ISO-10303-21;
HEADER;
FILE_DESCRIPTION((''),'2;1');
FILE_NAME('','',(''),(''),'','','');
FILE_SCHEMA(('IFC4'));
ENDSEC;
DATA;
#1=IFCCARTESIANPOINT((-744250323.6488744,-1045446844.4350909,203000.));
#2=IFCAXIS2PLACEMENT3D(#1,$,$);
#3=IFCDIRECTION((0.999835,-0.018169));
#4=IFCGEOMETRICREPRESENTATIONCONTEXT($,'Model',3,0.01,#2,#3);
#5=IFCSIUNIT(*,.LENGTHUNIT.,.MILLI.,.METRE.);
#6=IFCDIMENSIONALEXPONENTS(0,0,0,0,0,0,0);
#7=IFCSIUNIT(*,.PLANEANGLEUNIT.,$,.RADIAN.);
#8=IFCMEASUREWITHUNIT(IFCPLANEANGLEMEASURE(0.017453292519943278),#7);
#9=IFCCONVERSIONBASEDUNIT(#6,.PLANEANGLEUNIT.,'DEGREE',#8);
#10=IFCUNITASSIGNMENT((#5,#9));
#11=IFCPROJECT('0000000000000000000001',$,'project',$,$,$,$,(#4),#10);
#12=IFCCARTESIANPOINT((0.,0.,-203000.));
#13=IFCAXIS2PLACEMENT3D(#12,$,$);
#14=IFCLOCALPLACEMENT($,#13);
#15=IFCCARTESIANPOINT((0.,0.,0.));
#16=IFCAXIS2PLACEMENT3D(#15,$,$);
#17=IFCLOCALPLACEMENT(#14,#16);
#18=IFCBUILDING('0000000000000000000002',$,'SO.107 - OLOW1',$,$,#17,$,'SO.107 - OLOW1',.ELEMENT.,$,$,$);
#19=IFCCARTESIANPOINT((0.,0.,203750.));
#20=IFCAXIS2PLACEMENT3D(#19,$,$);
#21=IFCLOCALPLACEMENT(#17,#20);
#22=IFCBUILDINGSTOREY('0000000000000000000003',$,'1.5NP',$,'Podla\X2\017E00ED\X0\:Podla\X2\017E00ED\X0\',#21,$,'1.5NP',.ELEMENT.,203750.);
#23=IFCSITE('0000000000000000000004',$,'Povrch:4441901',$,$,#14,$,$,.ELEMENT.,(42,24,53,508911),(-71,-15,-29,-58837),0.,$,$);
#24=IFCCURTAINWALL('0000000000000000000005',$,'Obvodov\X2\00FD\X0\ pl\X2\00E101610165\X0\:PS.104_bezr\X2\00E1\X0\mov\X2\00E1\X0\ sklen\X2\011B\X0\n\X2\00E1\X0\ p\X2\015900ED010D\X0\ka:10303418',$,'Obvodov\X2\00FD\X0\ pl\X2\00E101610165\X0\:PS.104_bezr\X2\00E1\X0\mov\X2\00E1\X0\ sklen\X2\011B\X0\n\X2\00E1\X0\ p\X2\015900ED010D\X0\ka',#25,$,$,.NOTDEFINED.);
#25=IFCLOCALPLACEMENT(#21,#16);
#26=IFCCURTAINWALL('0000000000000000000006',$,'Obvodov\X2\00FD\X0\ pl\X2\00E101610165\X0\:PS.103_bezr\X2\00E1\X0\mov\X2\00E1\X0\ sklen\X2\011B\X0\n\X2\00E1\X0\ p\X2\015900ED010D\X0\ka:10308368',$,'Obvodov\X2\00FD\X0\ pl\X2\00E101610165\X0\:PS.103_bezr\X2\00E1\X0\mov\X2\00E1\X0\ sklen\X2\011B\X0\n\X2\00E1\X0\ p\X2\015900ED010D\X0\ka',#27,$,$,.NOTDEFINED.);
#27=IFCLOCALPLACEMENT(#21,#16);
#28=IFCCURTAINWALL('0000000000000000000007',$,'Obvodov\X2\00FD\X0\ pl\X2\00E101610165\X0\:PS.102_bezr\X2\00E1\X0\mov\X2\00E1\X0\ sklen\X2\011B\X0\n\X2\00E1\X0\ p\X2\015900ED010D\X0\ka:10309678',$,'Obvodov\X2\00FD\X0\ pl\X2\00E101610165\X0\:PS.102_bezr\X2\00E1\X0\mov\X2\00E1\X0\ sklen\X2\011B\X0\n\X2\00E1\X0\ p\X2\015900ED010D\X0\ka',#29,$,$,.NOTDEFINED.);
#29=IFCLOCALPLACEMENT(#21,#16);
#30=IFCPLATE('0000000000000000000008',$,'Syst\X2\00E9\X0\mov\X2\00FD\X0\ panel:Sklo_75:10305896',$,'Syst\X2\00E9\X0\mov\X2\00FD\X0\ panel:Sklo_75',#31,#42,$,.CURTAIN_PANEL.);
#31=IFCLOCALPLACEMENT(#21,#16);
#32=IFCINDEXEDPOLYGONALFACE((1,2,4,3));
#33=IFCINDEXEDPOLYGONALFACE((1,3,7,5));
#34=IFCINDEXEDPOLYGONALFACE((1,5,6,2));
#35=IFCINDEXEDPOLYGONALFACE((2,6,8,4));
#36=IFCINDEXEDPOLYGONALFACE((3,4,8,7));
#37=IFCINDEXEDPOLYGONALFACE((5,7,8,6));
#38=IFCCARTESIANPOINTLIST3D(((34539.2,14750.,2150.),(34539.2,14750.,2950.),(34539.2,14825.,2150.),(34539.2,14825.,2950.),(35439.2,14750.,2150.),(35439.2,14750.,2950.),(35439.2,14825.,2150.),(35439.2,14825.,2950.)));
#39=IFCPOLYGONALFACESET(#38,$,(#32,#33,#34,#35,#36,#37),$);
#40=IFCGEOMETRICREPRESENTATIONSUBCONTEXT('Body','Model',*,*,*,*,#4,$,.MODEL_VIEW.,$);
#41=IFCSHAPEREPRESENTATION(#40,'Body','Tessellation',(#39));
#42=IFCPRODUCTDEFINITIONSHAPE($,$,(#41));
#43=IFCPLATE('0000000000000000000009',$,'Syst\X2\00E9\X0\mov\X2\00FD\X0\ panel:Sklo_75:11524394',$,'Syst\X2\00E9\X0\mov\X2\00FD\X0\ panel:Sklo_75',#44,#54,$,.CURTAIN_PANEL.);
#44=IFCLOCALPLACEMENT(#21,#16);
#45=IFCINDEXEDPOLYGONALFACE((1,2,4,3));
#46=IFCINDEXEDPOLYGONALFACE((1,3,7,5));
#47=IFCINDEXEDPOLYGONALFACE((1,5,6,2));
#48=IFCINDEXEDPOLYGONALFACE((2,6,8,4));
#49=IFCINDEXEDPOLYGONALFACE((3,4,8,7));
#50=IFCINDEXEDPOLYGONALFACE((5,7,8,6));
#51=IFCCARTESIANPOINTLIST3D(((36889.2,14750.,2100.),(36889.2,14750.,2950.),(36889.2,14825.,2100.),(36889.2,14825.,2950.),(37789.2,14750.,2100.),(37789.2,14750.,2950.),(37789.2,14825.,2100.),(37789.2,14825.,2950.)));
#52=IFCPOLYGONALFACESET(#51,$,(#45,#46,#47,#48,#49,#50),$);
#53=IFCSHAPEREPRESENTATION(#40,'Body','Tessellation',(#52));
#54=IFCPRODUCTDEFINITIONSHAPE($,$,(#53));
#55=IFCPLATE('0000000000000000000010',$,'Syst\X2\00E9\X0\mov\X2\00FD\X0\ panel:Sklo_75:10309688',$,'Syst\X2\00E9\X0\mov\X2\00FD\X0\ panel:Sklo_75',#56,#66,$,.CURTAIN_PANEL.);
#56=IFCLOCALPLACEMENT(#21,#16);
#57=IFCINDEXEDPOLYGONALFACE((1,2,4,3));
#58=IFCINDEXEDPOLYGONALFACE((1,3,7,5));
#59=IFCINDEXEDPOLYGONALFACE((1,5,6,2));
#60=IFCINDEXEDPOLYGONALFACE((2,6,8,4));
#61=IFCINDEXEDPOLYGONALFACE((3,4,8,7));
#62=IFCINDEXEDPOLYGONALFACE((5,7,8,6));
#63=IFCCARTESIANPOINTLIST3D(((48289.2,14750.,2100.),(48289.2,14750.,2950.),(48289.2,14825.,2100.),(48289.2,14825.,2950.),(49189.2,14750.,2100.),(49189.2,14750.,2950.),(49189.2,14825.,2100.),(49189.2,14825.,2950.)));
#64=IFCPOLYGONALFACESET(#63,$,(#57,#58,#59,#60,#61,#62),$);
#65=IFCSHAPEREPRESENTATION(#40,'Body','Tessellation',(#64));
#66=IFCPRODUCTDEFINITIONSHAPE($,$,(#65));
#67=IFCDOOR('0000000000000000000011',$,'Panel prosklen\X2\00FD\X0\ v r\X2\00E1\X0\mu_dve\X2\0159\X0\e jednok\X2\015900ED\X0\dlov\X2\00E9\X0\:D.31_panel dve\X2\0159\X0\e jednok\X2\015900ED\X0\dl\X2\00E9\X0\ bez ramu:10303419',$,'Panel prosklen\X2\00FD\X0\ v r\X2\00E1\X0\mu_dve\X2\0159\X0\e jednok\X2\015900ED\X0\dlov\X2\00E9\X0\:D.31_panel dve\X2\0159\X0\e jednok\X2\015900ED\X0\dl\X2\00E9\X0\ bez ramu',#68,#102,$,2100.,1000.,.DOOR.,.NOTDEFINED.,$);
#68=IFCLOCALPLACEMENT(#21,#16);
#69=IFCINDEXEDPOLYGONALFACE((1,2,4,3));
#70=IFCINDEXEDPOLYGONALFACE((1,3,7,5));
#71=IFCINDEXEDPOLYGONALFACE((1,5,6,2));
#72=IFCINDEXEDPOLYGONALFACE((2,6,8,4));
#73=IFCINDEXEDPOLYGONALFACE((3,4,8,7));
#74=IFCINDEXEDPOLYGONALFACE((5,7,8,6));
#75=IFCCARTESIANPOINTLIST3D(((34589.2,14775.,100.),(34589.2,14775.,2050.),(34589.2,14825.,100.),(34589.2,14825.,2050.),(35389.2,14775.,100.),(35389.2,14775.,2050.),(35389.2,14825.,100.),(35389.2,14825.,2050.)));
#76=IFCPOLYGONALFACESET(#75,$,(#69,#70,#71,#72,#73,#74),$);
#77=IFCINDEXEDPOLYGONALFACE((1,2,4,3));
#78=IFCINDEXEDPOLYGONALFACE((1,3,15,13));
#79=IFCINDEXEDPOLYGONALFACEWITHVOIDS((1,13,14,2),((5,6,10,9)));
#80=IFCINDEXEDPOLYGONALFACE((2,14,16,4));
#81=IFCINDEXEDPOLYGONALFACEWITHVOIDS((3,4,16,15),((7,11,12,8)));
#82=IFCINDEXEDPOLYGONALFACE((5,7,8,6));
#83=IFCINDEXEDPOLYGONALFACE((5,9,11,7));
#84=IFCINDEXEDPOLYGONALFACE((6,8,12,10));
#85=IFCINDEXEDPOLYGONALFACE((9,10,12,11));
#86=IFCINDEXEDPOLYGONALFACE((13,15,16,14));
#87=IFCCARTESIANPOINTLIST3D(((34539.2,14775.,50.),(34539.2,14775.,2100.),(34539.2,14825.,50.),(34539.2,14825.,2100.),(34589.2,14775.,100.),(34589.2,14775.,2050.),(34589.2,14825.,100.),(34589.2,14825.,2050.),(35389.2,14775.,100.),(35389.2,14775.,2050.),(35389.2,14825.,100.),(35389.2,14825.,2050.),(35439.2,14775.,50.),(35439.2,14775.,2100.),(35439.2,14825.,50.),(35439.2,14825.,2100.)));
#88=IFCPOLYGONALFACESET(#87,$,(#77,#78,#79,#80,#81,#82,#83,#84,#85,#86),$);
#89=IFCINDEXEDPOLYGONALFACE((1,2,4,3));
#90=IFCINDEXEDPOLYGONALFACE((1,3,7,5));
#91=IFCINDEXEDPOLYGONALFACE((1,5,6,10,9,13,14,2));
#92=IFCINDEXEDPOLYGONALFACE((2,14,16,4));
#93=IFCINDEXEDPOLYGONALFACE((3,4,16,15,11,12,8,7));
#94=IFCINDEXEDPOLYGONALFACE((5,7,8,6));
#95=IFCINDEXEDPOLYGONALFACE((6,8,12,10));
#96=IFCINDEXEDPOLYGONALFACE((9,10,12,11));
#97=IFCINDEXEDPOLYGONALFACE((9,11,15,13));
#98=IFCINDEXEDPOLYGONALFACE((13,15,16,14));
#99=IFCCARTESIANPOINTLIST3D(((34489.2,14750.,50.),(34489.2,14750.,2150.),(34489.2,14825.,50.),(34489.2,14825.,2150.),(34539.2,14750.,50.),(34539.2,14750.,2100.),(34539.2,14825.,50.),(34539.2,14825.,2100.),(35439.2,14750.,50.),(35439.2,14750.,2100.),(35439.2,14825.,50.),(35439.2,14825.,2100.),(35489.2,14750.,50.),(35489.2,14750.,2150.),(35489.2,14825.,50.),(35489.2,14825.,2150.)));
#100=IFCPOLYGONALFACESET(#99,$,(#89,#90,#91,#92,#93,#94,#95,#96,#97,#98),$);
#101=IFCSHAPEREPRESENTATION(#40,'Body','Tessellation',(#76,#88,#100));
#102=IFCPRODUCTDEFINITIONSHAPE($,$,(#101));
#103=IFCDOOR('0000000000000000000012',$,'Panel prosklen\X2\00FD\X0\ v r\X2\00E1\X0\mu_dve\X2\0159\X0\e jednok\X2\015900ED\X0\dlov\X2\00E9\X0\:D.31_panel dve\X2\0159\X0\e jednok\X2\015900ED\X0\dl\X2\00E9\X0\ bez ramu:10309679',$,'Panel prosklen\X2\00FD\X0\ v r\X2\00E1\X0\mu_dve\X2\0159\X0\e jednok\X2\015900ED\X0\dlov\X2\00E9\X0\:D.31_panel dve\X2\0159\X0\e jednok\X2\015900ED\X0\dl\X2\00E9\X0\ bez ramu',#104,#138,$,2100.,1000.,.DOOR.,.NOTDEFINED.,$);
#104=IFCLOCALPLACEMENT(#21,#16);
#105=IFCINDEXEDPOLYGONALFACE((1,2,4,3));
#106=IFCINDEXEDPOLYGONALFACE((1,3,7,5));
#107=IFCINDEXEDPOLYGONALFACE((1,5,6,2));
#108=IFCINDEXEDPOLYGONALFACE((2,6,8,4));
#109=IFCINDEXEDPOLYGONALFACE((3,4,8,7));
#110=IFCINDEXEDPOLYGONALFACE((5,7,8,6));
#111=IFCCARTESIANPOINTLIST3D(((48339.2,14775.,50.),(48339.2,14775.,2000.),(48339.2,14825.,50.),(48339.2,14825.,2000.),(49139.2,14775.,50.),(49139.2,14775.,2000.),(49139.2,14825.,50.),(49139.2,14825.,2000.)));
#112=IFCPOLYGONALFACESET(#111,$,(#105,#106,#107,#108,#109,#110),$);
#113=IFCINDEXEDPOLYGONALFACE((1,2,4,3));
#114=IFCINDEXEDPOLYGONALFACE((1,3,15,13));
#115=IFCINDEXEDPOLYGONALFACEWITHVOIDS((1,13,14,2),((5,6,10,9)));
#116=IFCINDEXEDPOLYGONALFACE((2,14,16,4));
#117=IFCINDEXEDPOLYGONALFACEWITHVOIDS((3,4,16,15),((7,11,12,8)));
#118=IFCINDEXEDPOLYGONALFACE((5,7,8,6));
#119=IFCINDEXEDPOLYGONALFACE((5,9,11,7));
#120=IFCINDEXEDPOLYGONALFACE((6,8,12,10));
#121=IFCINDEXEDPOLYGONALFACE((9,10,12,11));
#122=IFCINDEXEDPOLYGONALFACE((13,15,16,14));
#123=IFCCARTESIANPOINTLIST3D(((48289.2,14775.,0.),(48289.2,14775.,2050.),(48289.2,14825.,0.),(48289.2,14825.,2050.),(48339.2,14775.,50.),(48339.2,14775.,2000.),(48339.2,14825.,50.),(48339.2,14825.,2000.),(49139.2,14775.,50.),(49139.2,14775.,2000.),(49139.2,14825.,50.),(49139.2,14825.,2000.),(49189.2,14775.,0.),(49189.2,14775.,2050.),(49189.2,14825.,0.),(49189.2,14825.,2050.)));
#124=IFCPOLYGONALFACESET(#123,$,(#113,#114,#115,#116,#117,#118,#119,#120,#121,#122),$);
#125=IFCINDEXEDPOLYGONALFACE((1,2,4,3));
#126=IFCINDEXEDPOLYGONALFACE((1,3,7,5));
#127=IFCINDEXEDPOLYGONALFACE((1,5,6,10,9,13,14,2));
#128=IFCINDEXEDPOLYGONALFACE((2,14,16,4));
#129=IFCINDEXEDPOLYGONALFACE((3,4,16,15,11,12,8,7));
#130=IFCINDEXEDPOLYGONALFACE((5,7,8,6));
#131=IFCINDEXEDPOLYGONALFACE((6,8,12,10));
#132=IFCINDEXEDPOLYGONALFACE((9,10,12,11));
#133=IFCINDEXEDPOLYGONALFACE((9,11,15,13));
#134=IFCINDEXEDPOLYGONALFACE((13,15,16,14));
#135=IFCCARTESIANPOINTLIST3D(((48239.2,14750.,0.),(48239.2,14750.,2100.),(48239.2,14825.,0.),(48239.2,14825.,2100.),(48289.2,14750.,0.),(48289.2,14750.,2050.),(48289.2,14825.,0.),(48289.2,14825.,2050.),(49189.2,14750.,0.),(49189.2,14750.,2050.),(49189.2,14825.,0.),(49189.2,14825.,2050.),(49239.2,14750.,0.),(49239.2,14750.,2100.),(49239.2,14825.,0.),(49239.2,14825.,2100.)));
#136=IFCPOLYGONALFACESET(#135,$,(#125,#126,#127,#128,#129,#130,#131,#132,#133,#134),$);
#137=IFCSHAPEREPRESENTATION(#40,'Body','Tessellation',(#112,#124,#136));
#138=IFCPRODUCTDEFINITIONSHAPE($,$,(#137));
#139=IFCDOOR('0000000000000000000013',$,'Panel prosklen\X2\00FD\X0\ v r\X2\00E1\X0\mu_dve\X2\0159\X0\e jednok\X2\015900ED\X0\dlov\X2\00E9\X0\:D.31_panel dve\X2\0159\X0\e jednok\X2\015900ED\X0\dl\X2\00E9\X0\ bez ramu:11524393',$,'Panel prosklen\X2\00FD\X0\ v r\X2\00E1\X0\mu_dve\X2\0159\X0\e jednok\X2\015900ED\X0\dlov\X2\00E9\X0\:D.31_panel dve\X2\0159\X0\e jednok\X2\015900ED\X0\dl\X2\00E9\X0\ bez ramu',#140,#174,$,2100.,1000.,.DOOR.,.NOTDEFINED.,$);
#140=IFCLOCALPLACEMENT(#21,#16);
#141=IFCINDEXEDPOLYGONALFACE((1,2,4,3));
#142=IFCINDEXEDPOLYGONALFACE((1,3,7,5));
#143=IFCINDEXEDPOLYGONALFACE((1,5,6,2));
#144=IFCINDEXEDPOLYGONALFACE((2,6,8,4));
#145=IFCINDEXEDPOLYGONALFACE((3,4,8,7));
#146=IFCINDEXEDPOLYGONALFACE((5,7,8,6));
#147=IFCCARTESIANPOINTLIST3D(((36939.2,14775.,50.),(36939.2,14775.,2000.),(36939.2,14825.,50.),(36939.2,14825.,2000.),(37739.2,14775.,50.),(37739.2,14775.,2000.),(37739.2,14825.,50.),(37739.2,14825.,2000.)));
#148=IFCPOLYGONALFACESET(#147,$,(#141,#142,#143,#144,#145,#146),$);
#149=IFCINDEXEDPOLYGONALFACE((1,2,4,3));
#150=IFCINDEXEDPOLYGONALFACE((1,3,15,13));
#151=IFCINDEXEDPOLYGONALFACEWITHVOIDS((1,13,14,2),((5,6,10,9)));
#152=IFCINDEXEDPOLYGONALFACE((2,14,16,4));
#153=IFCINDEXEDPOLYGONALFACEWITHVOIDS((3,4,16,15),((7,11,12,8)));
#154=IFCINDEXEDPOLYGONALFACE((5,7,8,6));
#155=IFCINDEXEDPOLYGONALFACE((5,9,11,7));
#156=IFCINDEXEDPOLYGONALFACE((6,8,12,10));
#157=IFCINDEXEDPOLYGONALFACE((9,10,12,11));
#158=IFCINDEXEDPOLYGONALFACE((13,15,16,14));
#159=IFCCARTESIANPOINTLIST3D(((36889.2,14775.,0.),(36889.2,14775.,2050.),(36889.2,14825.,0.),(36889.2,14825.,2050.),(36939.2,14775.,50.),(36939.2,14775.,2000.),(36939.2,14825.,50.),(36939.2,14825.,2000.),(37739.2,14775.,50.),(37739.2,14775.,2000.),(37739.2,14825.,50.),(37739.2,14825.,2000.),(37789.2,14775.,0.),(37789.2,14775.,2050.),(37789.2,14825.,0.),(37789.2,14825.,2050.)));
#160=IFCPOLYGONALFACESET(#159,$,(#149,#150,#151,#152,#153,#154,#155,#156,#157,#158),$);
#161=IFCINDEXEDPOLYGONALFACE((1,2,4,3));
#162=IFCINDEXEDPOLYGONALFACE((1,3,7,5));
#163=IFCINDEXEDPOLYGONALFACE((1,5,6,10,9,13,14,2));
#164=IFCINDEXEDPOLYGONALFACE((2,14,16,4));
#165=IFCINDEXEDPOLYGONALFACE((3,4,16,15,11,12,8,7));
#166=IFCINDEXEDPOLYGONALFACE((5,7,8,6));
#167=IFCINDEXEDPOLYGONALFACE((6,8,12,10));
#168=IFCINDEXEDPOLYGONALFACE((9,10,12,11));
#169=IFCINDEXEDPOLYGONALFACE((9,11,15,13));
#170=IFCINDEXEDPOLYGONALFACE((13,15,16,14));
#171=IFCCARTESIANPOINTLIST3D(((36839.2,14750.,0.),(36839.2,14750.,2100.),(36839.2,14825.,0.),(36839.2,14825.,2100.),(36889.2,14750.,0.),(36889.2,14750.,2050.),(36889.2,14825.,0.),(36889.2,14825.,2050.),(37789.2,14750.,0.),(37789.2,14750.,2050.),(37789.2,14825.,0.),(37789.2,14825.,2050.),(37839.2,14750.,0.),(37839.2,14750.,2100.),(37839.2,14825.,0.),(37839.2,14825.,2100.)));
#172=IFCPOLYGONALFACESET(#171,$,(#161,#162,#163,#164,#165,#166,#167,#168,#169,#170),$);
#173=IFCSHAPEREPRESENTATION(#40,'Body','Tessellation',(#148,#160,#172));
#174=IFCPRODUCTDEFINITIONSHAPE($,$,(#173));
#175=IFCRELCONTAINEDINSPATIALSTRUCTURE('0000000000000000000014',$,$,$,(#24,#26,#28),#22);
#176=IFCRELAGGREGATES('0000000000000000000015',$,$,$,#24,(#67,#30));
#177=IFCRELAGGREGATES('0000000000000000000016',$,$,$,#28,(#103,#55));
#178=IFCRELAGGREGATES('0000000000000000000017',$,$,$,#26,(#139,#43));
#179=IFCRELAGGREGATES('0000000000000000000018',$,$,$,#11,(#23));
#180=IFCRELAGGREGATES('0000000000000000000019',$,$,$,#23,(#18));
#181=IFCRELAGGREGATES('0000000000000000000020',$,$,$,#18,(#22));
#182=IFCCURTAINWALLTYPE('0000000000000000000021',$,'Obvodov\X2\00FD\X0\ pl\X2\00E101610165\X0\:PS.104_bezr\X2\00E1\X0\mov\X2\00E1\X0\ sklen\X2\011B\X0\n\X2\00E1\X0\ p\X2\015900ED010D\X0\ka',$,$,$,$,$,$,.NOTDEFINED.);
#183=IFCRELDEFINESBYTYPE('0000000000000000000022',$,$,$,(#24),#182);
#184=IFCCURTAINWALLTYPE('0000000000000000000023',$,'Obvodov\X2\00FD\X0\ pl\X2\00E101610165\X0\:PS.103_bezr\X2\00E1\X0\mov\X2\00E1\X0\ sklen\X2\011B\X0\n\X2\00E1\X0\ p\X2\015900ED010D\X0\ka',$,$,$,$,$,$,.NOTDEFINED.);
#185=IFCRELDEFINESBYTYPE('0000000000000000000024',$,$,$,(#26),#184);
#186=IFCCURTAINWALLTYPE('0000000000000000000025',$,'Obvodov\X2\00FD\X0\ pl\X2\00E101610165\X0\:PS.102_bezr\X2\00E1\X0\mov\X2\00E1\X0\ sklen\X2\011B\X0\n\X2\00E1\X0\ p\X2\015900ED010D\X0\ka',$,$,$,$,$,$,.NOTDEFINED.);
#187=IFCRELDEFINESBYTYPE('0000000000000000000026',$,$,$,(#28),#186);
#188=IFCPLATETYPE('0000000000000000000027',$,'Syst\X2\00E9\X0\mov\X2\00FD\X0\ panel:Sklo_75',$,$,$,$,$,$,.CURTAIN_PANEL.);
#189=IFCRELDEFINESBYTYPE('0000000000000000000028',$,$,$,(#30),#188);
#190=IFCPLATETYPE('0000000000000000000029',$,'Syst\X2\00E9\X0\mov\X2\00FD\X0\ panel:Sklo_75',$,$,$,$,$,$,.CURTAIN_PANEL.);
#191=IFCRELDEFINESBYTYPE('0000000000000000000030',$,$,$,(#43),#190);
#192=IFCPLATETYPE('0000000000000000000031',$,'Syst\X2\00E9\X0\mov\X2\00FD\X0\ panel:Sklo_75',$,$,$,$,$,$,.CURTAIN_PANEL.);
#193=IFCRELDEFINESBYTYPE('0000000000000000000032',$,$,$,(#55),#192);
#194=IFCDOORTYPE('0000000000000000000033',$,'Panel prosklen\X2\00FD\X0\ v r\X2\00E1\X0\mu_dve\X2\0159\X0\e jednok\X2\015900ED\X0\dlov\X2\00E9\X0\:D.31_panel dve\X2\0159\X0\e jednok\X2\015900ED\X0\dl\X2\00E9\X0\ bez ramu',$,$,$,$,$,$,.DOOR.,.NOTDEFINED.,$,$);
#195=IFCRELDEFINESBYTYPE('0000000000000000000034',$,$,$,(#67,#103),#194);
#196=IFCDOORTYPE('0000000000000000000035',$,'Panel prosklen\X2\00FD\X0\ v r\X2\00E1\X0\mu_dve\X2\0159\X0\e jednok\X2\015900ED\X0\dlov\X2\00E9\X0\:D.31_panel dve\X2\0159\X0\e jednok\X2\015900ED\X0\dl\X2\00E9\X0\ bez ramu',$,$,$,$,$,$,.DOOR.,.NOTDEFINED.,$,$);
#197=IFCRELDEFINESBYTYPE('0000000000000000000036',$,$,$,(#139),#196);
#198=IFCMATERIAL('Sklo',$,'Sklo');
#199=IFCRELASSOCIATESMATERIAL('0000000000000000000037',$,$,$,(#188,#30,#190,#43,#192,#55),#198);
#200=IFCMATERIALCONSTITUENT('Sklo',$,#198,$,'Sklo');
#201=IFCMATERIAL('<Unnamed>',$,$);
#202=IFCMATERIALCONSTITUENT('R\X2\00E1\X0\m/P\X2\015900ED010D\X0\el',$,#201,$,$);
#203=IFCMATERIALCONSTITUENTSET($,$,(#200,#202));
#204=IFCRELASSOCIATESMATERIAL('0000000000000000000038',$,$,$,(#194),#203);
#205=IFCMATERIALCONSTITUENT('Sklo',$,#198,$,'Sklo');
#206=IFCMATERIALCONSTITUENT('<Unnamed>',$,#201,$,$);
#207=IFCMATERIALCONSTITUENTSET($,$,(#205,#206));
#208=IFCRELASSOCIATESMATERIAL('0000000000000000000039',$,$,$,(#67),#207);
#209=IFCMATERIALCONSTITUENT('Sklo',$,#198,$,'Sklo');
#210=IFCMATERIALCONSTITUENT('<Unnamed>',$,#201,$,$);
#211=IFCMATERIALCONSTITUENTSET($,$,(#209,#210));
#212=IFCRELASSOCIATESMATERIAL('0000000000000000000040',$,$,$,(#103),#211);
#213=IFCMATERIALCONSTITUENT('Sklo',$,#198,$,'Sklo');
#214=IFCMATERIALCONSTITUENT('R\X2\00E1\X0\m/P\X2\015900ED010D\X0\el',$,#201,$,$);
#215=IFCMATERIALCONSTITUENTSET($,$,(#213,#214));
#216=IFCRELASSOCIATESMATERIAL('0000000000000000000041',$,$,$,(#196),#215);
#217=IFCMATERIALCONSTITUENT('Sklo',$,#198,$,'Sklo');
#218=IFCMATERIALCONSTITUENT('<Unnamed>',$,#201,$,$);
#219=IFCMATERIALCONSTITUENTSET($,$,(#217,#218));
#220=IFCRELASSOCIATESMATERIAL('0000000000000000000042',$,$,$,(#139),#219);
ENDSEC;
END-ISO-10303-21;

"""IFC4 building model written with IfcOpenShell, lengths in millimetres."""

from ifc_helpers import new_model, entity, si_unit, converted_unit, direction, frame, origin, place, context, subcontext, project, spatial, indexed_curve, outline, extrude, source, transform, mapped, material, constituent, constituent_set, type_object, type_shapes, element, aggregate, save


model = new_model("IFC4")

# Units and contexts
model_context = context("Model", 3, precision=0.01, world=frame((-744250323.6488744, -1045446844.4350909, 203000.0)), true_north=direction((0.999835, -0.018169)))
body_context = subcontext(model_context, "Body", "Model", "MODEL_VIEW")
ifc_project = project(units=[si_unit("LENGTHUNIT", "METRE", prefix="MILLI"), converted_unit("PLANEANGLEUNIT", "DEGREE", entity("IfcPlaneAngleMeasure", 0.017453292519943278), si_unit("PLANEANGLEUNIT", "RADIAN"), dimensions=[0, 0, 0, 0, 0, 0, 0])], contexts=[model_context])

# Site, building, storey
site_placement = place(None, frame((0.0, 0.0, -203000.0)))
site = spatial("IfcSite", under=ifc_project, at=site_placement, Name="Povrch:4441901", CompositionType="ELEMENT", RefLatitude=(42, 24, 53, 508911), RefLongitude=(-71, -15, -29, -58837), RefElevation=0.0)
building_placement = place(site_placement, origin())
building = spatial("IfcBuilding", under=site, at=building_placement, Name="SO.107 - OLOW1", LongName="SO.107 - OLOW1", CompositionType="ELEMENT")
storey_placement = place(building_placement, frame((0.0, 0.0, 203750.0)))
storey = spatial("IfcBuildingStorey", under=building, at=storey_placement, Name="1.5NP", ObjectType="Podlaží:Podlaží", LongName="1.5NP", CompositionType="ELEMENT", Elevation=203750.0)

# Curtain walls
curtain_wall_type_1 = type_object("IfcCurtainWallType", Name="Obvodový plášť:PS.104_bezrámová skleněná příčka", PredefinedType="NOTDEFINED")
curtain_wall_1_placement = place(storey_placement, frame((0.0, 0.0, -203750.0)))
curtain_wall_1 = element("IfcCurtainWall", 1, at=curtain_wall_1_placement, inside=storey, type_object=curtain_wall_type_1, Name="Obvodový plášť:PS.104_bezrámová skleněná příčka:10303418", ObjectType="Obvodový plášť:PS.104_bezrámová skleněná příčka", PredefinedType="NOTDEFINED")
ifc_material_1 = material(Name="<Unnamed>")
curtain_wall_type_2 = type_object("IfcCurtainWallType", Name="Obvodový plášť:PS.103_bezrámová skleněná příčka", PredefinedType="NOTDEFINED")
curtain_wall_2_placement = place(storey_placement, frame((0.0, 0.0, -203750.0)))
curtain_wall_2 = element("IfcCurtainWall", 2, at=curtain_wall_2_placement, inside=storey, type_object=curtain_wall_type_2, Name="Obvodový plášť:PS.103_bezrámová skleněná příčka:10308368", ObjectType="Obvodový plášť:PS.103_bezrámová skleněná příčka", PredefinedType="NOTDEFINED")
curtain_wall_type_3 = type_object("IfcCurtainWallType", Name="Obvodový plášť:PS.102_bezrámová skleněná příčka", PredefinedType="NOTDEFINED")
curtain_wall_3_placement = place(storey_placement, frame((0.0, 0.0, -203750.0)))
curtain_wall_3 = element("IfcCurtainWall", 3, at=curtain_wall_3_placement, inside=storey, type_object=curtain_wall_type_3, Name="Obvodový plášť:PS.102_bezrámová skleněná příčka:10309678", ObjectType="Obvodový plášť:PS.102_bezrámová skleněná příčka", PredefinedType="NOTDEFINED")

# Plates
ifc_material_2 = material(Name="Sklo", Category="Sklo")
plate_type_1 = type_object("IfcPlateType", Name="Systémový panel:Sklo_75", PredefinedType="CURTAIN_PANEL", material=ifc_material_2)
shared_shape_1 = source(origin(), body_context, "Body", "SweptSolid", [
    extrude(outline(indexed_curve([(-37.5, -450.0), (37.5, -450.0), (37.5, 450.0), (-37.5, 450.0), (-37.5, -450.0)], self_intersect=False)), frame((0.0, -37.5, 0.0), z_axis=(0.0, 0.0, 1.0), x_axis=(0.0, 1.0, 0.0)), (0.0, 0.0, 1.0), 800.0),
])
type_shapes(plate_type_1, [shared_shape_1])
plate_1_placement = place(curtain_wall_1_placement, frame((34989.2, 14750.0, 205900.0), z_axis=(0.0, 0.0, 1.0), x_axis=(-1.0, 0.0, 0.0)))
plate_1 = element("IfcPlate", 4, at=plate_1_placement, type_object=plate_type_1, material=ifc_material_2, Name="Systémový panel:Sklo_75:10305896", ObjectType="Systémový panel:Sklo_75", PredefinedType="CURTAIN_PANEL", context=body_context, shape_type="MappedRepresentation", body=[
    mapped(shared_shape_1, transform((0.0, 0.0, 0.0), scale=1.0)),
])
plate_type_2 = type_object("IfcPlateType", Name="Systémový panel:Sklo_75", PredefinedType="CURTAIN_PANEL", material=ifc_material_2)
shared_shape_2 = source(origin(), body_context, "Body", "SweptSolid", [
    extrude(outline(indexed_curve([(-37.5, -450.0), (37.5, -450.0), (37.5, 450.0), (-37.5, 450.0), (-37.5, -450.0)], self_intersect=False)), frame((0.0, 37.5, 0.0), z_axis=(0.0, 0.0, 1.0), x_axis=(0.0, 1.0, 0.0)), (0.0, 0.0, 1.0), 850.0),
])
type_shapes(plate_type_2, [shared_shape_2])
plate_2_placement = place(curtain_wall_2_placement, frame((37339.2, 14750.0, 205850.0)))
plate_2 = element("IfcPlate", 5, at=plate_2_placement, type_object=plate_type_2, material=ifc_material_2, Name="Systémový panel:Sklo_75:11524394", ObjectType="Systémový panel:Sklo_75", PredefinedType="CURTAIN_PANEL", context=body_context, shape_type="MappedRepresentation", body=[
    mapped(shared_shape_2, transform((0.0, 0.0, 0.0), scale=1.0)),
])
plate_type_3 = type_object("IfcPlateType", Name="Systémový panel:Sklo_75", PredefinedType="CURTAIN_PANEL", material=ifc_material_2)
shared_shape_3 = source(origin(), body_context, "Body", "SweptSolid", [
    extrude(outline(indexed_curve([(-37.5, -450.0), (37.5, -450.0), (37.5, 450.0), (-37.5, 450.0), (-37.5, -450.0)], self_intersect=False)), frame((0.0, -37.5, 0.0), z_axis=(0.0, 0.0, 1.0), x_axis=(0.0, 1.0, 0.0)), (0.0, 0.0, 1.0), 850.0),
])
type_shapes(plate_type_3, [shared_shape_3])
plate_3_placement = place(curtain_wall_3_placement, frame((48739.2, 14750.0, 205850.0), z_axis=(0.0, 0.0, 1.0), x_axis=(-1.0, 0.0, 0.0)))
plate_3 = element("IfcPlate", 6, at=plate_3_placement, type_object=plate_type_3, material=ifc_material_2, Name="Systémový panel:Sklo_75:10309688", ObjectType="Systémový panel:Sklo_75", PredefinedType="CURTAIN_PANEL", context=body_context, shape_type="MappedRepresentation", body=[
    mapped(shared_shape_3, transform((0.0, 0.0, 0.0), scale=1.0)),
])

# Doors
ifc_constituent_1 = constituent(ifc_material_2, Name="Sklo", Category="Sklo")
ifc_constituent_2 = constituent(ifc_material_1, Name="<Unnamed>")
ifc_constituent_set_1 = constituent_set(constituents=[ifc_constituent_1, ifc_constituent_2])
ifc_constituent_3 = constituent(ifc_material_2, Name="Sklo", Category="Sklo")
ifc_constituent_4 = constituent(ifc_material_1, Name="Rám/Příčel")
ifc_constituent_set_2 = constituent_set(constituents=[ifc_constituent_3, ifc_constituent_4])
door_type_1 = type_object("IfcDoorType", Name="Panel prosklený v rámu_dveře jednokřídlové:D.31_panel dveře jednokřídlé bez ramu", OperationType="NOTDEFINED", PredefinedType="DOOR", material=ifc_constituent_set_2)
shared_shape_4 = source(origin(), body_context, "Body", "SweptSolid", [
    extrude(outline(indexed_curve([(-400.0, -25.0), (400.0, -25.0), (400.0, 25.0), (-400.0, 25.0), (-400.0, -25.0)], self_intersect=False)), frame((0.0, -50.0, 50.0), z_axis=(0.0, 0.0, 1.0), x_axis=(-1.0, 0.0, 0.0)), (0.0, 0.0, 1.0), 1950.0),
    extrude(outline(indexed_curve([(-1025.0, -450.0), (1025.0, -450.0), (1025.0, 450.0), (-1025.0, 450.0), (-1025.0, -450.0)], self_intersect=False), holes=[indexed_curve([(-975.0, -400.0), (-975.0, 400.0), (975.0, 400.0), (975.0, -400.0), (-975.0, -400.0)], self_intersect=False)]), frame((0.0, -75.0, 1025.0), z_axis=(0.0, 1.0, 0.0), x_axis=(0.0, 0.0, -1.0)), (0.0, 0.0, 1.0), 50.0),
    extrude(outline(indexed_curve([(-1062.5, -500.0), (1037.5, -500.0), (1037.5, -450.0), (-1012.5, -450.0), (-1012.5, 450.0), (1037.5, 450.0), (1037.5, 500.0), (-1062.5, 500.0), (-1062.5, -500.0)], self_intersect=False)), frame((0.0, -75.0, 1037.5), z_axis=(0.0, 1.0, 0.0), x_axis=(0.0, 0.0, -1.0)), (0.0, 0.0, 1.0), 75.0),
])
type_shapes(door_type_1, [shared_shape_4])
door_1_placement = place(curtain_wall_1_placement, frame((34989.2, 14750.0, 203800.0), z_axis=(0.0, 0.0, 1.0), x_axis=(-1.0, 0.0, 0.0)))
door_1 = element("IfcDoor", 7, at=door_1_placement, type_object=door_type_1, material=ifc_constituent_set_1, Name="Panel prosklený v rámu_dveře jednokřídlové:D.31_panel dveře jednokřídlé bez ramu:10303419", ObjectType="Panel prosklený v rámu_dveře jednokřídlové:D.31_panel dveře jednokřídlé bez ramu", OperationType="NOTDEFINED", OverallHeight=2100.0, OverallWidth=1000.0, PredefinedType="DOOR", context=body_context, shape_type="MappedRepresentation", body=[
    mapped(shared_shape_4, transform((0.0, 0.0, 0.0), scale=1.0)),
])
aggregate(curtain_wall_1, [door_1, plate_1])
ifc_constituent_5 = constituent(ifc_material_2, Name="Sklo", Category="Sklo")
ifc_constituent_6 = constituent(ifc_material_1, Name="<Unnamed>")
ifc_constituent_set_3 = constituent_set(constituents=[ifc_constituent_5, ifc_constituent_6])
door_2_placement = place(curtain_wall_3_placement, frame((48739.2, 14750.0, 203750.0), z_axis=(0.0, 0.0, 1.0), x_axis=(-1.0, 0.0, 0.0)))
door_2 = element("IfcDoor", 8, at=door_2_placement, type_object=door_type_1, material=ifc_constituent_set_3, Name="Panel prosklený v rámu_dveře jednokřídlové:D.31_panel dveře jednokřídlé bez ramu:10309679", ObjectType="Panel prosklený v rámu_dveře jednokřídlové:D.31_panel dveře jednokřídlé bez ramu", OperationType="NOTDEFINED", OverallHeight=2100.0, OverallWidth=1000.0, PredefinedType="DOOR", context=body_context, shape_type="MappedRepresentation", body=[
    mapped(shared_shape_4, transform((0.0, 0.0, 0.0), scale=1.0)),
])
aggregate(curtain_wall_3, [door_2, plate_3])
ifc_constituent_7 = constituent(ifc_material_2, Name="Sklo", Category="Sklo")
ifc_constituent_8 = constituent(ifc_material_1, Name="<Unnamed>")
ifc_constituent_set_4 = constituent_set(constituents=[ifc_constituent_7, ifc_constituent_8])
ifc_constituent_9 = constituent(ifc_material_2, Name="Sklo", Category="Sklo")
ifc_constituent_10 = constituent(ifc_material_1, Name="Rám/Příčel")
ifc_constituent_set_5 = constituent_set(constituents=[ifc_constituent_9, ifc_constituent_10])
door_type_2 = type_object("IfcDoorType", Name="Panel prosklený v rámu_dveře jednokřídlové:D.31_panel dveře jednokřídlé bez ramu", OperationType="NOTDEFINED", PredefinedType="DOOR", material=ifc_constituent_set_5)
shared_shape_5 = source(origin(), body_context, "Body", "SweptSolid", [
    extrude(outline(indexed_curve([(-25.0, -400.0), (25.0, -400.0), (25.0, 400.0), (-25.0, 400.0), (-25.0, -400.0)], self_intersect=False)), frame((0.0, -50.0, 50.0), z_axis=(0.0, 0.0, 1.0), x_axis=(0.0, -1.0, 0.0)), (0.0, 0.0, 1.0), 1950.0),
    extrude(outline(indexed_curve([(-1025.0, -450.0), (1025.0, -450.0), (1025.0, 450.0), (-1025.0, 450.0), (-1025.0, -450.0)], self_intersect=False), holes=[indexed_curve([(-975.0, -400.0), (-975.0, 400.0), (975.0, 400.0), (975.0, -400.0), (-975.0, -400.0)], self_intersect=False)]), frame((0.0, -25.0, 1025.0), z_axis=(0.0, -1.0, 0.0), x_axis=(0.0, 0.0, -1.0)), (0.0, 0.0, 1.0), 50.0),
    extrude(outline(indexed_curve([(-1062.5, -500.0), (1037.5, -500.0), (1037.5, -450.0), (-1012.5, -450.0), (-1012.5, 450.0), (1037.5, 450.0), (1037.5, 500.0), (-1062.5, 500.0), (-1062.5, -500.0)], self_intersect=False)), frame((0.0, 0.0, 1037.5), z_axis=(0.0, -1.0, 0.0), x_axis=(0.0, 0.0, -1.0)), (0.0, 0.0, 1.0), 75.0),
])
type_shapes(door_type_2, [shared_shape_5])
door_3_placement = place(curtain_wall_2_placement, frame((37339.2, 14750.0, 203750.0), z_axis=(0.0, 0.0, 1.0), x_axis=(-1.0, 0.0, 0.0)))
door_3 = element("IfcDoor", 9, at=door_3_placement, type_object=door_type_2, material=ifc_constituent_set_4, Name="Panel prosklený v rámu_dveře jednokřídlové:D.31_panel dveře jednokřídlé bez ramu:11524393", ObjectType="Panel prosklený v rámu_dveře jednokřídlové:D.31_panel dveře jednokřídlé bez ramu", OperationType="NOTDEFINED", OverallHeight=2100.0, OverallWidth=1000.0, PredefinedType="DOOR", context=body_context, shape_type="MappedRepresentation", body=[
    mapped(shared_shape_5, transform((0.0, 0.0, 0.0), scale=1.0)),
])
aggregate(curtain_wall_2, [door_3, plate_2])

save(model, "model.ifc")
